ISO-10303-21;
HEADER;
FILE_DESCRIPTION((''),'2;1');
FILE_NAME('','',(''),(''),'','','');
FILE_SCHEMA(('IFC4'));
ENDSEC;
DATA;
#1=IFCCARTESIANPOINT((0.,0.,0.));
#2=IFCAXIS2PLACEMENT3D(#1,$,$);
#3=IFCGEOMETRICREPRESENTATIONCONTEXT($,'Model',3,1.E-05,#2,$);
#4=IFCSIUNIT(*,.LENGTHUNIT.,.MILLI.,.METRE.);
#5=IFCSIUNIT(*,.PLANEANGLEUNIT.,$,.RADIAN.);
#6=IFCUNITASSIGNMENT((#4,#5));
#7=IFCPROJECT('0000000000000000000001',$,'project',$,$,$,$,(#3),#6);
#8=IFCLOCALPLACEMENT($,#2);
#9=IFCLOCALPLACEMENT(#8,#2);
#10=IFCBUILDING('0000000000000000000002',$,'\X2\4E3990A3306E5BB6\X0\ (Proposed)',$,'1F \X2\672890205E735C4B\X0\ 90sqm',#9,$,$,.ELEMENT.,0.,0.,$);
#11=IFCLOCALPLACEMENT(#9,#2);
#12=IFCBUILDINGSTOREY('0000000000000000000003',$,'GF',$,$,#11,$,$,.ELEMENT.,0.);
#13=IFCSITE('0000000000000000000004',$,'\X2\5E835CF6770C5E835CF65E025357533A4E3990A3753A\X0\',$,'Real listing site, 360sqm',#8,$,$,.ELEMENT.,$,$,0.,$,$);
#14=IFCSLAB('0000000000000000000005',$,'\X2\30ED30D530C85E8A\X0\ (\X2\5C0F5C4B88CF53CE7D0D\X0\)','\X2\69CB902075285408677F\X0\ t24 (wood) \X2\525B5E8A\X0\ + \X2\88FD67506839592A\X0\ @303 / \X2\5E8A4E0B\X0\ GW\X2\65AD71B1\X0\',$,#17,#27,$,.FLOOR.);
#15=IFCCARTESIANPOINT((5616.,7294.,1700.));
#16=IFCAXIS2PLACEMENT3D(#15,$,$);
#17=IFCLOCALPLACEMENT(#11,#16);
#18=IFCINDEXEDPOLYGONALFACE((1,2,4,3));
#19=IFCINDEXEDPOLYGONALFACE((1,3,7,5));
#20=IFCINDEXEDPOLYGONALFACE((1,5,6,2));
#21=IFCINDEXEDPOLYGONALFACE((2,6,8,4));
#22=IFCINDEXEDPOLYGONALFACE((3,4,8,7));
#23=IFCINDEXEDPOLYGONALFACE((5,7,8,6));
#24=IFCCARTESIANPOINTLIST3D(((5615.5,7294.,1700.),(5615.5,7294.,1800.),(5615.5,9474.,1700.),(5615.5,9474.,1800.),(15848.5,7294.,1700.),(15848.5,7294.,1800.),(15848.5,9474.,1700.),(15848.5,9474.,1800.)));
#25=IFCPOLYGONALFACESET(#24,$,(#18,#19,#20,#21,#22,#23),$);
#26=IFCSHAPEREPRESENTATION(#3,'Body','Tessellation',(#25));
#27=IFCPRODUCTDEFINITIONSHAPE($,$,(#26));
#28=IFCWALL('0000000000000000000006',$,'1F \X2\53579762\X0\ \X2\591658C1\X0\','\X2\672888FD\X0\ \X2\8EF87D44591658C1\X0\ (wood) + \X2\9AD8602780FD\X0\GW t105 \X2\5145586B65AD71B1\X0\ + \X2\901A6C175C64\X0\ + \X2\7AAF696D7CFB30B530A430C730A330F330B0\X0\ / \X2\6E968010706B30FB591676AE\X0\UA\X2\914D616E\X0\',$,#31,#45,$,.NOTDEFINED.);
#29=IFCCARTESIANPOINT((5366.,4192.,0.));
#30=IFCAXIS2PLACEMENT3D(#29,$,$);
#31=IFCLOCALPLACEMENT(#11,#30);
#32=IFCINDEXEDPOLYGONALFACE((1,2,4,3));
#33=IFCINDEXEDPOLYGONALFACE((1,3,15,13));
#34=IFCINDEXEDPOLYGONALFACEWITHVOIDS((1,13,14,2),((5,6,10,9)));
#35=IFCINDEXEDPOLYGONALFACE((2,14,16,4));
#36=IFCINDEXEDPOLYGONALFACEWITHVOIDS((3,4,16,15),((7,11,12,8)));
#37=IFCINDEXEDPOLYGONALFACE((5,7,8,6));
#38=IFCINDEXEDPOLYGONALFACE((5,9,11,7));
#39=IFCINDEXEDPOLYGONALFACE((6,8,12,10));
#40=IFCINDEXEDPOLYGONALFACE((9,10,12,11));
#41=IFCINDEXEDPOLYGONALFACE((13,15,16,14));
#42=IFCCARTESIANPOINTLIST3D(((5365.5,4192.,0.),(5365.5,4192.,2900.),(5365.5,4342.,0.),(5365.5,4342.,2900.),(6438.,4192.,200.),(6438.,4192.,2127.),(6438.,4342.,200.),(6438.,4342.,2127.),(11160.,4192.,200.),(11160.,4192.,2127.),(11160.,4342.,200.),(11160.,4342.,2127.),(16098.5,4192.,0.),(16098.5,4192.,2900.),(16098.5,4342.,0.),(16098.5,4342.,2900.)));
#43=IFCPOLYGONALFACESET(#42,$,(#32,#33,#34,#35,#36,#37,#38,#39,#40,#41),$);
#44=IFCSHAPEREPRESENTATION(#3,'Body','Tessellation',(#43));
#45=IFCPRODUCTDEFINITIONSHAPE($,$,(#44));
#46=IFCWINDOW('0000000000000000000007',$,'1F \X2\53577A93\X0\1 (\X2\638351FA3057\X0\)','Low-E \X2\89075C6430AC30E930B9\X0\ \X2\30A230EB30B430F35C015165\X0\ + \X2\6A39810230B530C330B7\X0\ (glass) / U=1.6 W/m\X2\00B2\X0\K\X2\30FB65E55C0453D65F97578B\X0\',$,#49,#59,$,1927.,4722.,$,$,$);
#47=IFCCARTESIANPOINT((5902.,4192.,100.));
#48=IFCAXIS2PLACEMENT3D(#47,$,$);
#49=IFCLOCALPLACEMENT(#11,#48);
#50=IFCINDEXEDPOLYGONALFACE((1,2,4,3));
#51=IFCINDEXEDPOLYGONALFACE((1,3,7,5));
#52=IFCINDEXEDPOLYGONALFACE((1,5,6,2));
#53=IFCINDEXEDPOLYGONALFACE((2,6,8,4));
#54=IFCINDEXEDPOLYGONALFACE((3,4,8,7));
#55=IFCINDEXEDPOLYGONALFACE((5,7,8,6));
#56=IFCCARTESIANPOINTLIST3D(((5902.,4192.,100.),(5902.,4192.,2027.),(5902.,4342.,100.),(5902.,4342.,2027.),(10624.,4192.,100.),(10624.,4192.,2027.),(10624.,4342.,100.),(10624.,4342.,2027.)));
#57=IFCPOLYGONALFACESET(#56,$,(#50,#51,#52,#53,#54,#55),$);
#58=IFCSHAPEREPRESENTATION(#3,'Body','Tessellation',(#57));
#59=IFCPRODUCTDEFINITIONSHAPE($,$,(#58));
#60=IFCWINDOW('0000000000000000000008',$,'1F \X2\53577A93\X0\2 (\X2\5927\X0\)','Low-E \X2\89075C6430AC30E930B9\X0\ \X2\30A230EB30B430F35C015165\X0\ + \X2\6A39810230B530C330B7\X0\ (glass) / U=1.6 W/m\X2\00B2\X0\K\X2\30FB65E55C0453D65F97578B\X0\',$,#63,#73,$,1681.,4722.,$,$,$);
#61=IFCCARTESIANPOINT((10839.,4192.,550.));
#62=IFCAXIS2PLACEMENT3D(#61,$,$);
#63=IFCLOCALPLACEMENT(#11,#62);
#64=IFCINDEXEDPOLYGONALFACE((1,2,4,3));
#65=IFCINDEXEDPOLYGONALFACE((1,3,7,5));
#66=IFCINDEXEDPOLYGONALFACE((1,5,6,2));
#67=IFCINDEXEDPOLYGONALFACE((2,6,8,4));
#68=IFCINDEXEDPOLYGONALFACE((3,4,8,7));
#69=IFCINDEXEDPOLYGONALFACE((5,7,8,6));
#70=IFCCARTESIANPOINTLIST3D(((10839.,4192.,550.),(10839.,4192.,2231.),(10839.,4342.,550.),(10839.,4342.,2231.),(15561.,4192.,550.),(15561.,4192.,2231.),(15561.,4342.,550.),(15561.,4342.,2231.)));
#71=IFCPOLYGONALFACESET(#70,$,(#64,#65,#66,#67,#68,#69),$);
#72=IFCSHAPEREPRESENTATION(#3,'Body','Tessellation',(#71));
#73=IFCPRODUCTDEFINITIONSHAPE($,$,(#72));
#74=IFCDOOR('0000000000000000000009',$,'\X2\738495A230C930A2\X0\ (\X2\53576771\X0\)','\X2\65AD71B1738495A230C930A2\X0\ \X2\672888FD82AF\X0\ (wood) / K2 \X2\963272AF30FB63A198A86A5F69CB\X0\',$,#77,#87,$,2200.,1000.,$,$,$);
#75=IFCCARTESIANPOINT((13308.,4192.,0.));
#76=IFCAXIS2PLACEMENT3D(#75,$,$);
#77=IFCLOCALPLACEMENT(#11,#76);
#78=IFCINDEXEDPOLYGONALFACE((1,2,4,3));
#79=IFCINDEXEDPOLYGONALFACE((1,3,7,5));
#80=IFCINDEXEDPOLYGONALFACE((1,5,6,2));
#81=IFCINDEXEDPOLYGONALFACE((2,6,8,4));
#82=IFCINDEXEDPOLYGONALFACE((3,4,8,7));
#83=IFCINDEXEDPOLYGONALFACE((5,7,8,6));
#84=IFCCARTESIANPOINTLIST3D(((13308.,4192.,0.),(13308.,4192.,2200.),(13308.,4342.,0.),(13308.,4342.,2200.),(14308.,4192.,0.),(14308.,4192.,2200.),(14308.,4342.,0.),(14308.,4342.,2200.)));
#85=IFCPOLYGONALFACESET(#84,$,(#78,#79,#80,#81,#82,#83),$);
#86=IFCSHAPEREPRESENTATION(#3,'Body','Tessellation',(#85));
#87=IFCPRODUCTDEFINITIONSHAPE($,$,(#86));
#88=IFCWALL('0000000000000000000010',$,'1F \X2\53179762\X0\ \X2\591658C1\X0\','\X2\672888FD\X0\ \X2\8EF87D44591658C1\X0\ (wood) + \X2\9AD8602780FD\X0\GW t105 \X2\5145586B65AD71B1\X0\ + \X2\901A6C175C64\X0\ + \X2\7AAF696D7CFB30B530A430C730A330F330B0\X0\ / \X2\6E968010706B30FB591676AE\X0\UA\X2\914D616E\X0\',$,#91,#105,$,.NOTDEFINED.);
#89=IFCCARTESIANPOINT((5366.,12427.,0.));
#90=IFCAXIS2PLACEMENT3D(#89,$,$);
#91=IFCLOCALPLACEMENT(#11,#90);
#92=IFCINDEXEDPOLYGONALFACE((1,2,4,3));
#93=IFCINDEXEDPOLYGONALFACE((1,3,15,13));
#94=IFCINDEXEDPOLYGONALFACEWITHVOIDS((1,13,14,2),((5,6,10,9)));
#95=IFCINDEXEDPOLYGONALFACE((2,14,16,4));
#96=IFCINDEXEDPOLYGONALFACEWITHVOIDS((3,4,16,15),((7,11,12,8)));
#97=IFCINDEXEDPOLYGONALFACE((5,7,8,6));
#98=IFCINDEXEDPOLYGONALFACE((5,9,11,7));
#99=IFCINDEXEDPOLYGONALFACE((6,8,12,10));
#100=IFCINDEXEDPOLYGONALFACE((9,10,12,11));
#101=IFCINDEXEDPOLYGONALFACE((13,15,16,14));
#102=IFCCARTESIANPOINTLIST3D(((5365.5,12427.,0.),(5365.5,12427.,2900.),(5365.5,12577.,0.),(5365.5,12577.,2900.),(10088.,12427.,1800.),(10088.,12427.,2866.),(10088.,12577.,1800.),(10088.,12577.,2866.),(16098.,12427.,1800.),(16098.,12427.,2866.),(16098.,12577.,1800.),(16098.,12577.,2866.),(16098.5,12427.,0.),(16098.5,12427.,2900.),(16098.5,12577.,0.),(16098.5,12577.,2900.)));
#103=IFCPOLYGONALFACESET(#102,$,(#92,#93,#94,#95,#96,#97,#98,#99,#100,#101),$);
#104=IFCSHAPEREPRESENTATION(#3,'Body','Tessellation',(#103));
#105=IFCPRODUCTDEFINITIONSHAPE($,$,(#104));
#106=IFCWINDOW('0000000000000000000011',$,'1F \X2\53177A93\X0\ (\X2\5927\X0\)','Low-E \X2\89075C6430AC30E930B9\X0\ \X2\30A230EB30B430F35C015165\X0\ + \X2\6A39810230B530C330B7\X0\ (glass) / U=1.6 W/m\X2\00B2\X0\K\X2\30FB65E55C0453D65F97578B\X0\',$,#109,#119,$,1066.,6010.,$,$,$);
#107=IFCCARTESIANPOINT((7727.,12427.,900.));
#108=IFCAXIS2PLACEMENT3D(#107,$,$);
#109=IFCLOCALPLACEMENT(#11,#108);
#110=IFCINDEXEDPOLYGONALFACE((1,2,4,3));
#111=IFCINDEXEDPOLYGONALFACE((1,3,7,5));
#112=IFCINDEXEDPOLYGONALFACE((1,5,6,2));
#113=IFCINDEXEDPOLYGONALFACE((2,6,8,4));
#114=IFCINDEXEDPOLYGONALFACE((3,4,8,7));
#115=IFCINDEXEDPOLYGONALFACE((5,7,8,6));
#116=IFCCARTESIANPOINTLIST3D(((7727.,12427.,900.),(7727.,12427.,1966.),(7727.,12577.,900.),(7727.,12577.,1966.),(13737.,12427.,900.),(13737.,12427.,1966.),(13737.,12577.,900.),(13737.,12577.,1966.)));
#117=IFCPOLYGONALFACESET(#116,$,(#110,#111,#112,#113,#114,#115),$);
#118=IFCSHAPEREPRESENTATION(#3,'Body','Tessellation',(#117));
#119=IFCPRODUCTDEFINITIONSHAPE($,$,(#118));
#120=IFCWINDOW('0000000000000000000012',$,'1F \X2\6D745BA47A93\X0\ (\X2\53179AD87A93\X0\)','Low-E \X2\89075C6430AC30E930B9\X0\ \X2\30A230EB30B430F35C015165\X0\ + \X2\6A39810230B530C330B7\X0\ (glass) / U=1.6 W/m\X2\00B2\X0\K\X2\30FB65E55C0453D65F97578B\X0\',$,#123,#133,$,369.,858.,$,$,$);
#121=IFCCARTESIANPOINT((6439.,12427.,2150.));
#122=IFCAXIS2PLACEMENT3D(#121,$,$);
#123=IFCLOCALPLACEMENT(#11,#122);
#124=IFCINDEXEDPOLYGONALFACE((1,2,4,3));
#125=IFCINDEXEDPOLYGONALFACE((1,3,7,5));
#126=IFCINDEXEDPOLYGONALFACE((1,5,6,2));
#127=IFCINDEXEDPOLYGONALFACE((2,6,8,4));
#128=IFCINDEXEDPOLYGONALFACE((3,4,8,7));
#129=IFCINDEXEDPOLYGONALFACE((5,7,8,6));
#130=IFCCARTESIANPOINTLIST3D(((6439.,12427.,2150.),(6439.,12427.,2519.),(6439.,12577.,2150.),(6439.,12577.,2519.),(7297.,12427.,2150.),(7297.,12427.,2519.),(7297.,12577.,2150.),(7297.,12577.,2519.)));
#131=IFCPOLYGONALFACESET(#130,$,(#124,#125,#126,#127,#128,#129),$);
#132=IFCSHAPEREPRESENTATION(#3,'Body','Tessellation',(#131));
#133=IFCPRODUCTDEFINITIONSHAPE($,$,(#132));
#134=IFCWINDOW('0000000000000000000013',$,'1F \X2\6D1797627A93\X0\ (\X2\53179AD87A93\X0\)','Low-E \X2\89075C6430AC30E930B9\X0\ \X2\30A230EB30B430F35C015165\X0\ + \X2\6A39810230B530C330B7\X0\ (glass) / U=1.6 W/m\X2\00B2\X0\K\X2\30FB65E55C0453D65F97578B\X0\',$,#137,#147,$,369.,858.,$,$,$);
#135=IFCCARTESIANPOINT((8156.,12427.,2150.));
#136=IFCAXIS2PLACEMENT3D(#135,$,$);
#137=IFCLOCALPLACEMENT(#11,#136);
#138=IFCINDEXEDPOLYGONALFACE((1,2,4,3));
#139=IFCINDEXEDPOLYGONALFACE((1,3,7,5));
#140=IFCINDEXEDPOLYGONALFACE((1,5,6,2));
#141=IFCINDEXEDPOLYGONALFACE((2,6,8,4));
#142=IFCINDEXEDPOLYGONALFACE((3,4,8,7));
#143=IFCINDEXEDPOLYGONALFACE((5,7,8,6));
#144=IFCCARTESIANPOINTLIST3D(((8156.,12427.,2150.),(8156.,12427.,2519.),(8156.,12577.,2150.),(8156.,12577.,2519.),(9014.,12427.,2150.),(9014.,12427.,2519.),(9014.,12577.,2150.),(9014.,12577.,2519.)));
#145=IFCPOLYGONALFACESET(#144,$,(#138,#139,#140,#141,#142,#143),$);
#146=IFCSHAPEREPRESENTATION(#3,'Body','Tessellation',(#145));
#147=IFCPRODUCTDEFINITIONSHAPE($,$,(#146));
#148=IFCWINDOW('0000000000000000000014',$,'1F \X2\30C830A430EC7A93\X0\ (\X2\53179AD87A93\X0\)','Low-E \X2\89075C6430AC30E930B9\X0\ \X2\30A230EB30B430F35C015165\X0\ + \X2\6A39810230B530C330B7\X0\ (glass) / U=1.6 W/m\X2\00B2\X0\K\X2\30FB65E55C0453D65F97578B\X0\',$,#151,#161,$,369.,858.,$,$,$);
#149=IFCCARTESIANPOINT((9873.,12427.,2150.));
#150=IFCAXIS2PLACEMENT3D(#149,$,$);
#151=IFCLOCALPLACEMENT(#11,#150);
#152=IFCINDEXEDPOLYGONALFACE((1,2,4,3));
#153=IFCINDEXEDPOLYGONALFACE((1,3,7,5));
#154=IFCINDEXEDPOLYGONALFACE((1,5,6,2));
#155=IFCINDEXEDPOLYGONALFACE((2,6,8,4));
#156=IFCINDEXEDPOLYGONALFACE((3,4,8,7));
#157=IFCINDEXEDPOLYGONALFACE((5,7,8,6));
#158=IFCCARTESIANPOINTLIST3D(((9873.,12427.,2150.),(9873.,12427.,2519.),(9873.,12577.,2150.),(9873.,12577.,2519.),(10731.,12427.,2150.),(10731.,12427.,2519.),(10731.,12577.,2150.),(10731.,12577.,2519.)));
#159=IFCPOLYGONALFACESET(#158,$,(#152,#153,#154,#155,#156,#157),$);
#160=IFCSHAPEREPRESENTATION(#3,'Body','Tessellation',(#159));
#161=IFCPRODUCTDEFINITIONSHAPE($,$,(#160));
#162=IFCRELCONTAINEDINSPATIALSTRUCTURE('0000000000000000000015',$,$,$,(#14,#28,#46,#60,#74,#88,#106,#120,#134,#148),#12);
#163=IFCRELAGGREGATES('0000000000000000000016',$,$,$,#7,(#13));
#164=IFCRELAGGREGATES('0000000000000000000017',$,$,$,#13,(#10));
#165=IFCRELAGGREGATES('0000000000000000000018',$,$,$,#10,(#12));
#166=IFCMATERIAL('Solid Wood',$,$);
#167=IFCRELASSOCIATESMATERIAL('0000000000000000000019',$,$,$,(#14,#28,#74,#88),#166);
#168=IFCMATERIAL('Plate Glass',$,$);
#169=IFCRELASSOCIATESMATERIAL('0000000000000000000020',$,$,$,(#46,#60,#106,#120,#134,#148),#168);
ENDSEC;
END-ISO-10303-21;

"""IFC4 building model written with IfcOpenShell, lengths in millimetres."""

from ifc_helpers import new_model, si_unit, frame, frame_2d, origin, place, context, project, spatial, rectangle, extrude, material, element, fill, save


model = new_model("IFC4")

# Units and contexts
model_context = context("Model", 3, precision=1e-05, world=origin())
ifc_project = project(units=[si_unit("LENGTHUNIT", "METRE", prefix="MILLI"), si_unit("PLANEANGLEUNIT", "RADIAN")], contexts=[model_context])

# Site, building, storey
site_placement = place(None, origin())
site = spatial("IfcSite", under=ifc_project, at=site_placement, Name="広島県広島市南区丹那町", ObjectType="Real listing site, 360sqm", CompositionType="ELEMENT", RefElevation=0.0)
building_placement = place(site_placement, origin())
building = spatial("IfcBuilding", under=site, at=building_placement, Name="丹那の家 (Proposed)", ObjectType="1F 木造平屋 90sqm", CompositionType="ELEMENT", ElevationOfRefHeight=0.0, ElevationOfTerrain=0.0)
storey_placement = place(building_placement, origin())
storey = spatial("IfcBuildingStorey", under=building, at=storey_placement, Name="GF", CompositionType="ELEMENT", Elevation=0.0)

# Slab
ifc_material_1 = material(Name="Solid Wood")
slab_1_placement = place(storey_placement, frame((5616.0, 7294.0, 1700.0)))
element("IfcSlab", 1, at=slab_1_placement, inside=storey, material=ifc_material_1, Name="ロフト床 (小屋裏収納)", Description="構造用合板 t24 (wood) 剛床 + 製材根太 @303 / 床下 GW断熱", PredefinedType="FLOOR", context=model_context, shape_type="SweptSolid", body=[
    extrude(rectangle(XDim=10233.0, YDim=2180.0, at=frame_2d((5116.0, 1090.0))), frame((5616.0, 7294.0, 1700.0)), (0.0, 0.0, 1.0), 100.0),
])

# Wall, openings, windows, door
wall_1_placement = place(storey_placement, frame((5366.0, 4192.0, 0.0)))
wall_1 = element("IfcWall", 2, at=wall_1_placement, inside=storey, material=ifc_material_1, Name="1F 南面 外壁", Description="木製 軸組外壁 (wood) + 高性能GW t105 充填断熱 + 通気層 + 窯業系サイディング / 準耐火・外皮UA配慮", PredefinedType="NOTDEFINED", context=model_context, shape_type="SweptSolid", body=[
    extrude(rectangle(XDim=10733.0, YDim=150.0, at=frame_2d((5366.0, 75.0))), frame((5366.0, 4192.0, 0.0)), (0.0, 0.0, 1.0), 2900.0),
])
opening_1_placement = place(storey_placement, frame((5902.0, 4192.0, 100.0)))
opening_1 = element("IfcOpeningElement", 3, at=opening_1_placement, cuts=wall_1, PredefinedType="NOTDEFINED", context=model_context, shape_type="SweptSolid", body=[
    extrude(rectangle(XDim=4722.0, YDim=150.0, at=frame_2d((2361.0, 75.0))), frame((5902.0, 4192.0, 100.0)), (0.0, 0.0, 1.0), 1927.0),
])
opening_2_placement = place(storey_placement, frame((10839.0, 4192.0, 550.0)))
opening_2 = element("IfcOpeningElement", 4, at=opening_2_placement, cuts=wall_1, PredefinedType="NOTDEFINED", context=model_context, shape_type="SweptSolid", body=[
    extrude(rectangle(XDim=4722.0, YDim=150.0, at=frame_2d((2361.0, 75.0))), frame((10839.0, 4192.0, 550.0)), (0.0, 0.0, 1.0), 1681.0),
])
opening_3_placement = place(storey_placement, frame((13308.0, 4192.0, 0.0)))
opening_3 = element("IfcOpeningElement", 5, at=opening_3_placement, cuts=wall_1, PredefinedType="NOTDEFINED", context=model_context, shape_type="SweptSolid", body=[
    extrude(rectangle(XDim=1000.0, YDim=150.0, at=frame_2d((500.0, 75.0))), frame((13308.0, 4192.0, 0.0)), (0.0, 0.0, 1.0), 2200.0),
])
ifc_material_2 = material(Name="Plate Glass")
window_1_placement = place(storey_placement, frame((5902.0, 4192.0, 100.0)))
window_1 = element("IfcWindow", 6, at=window_1_placement, inside=storey, material=ifc_material_2, Name="1F 南窓1 (掃出し)", Description="Low-E 複層ガラス アルゴン封入 + 樹脂サッシ (glass) / U=1.6 W/m²K・日射取得型", OverallHeight=1927.0, OverallWidth=4722.0, context=model_context, shape_type="SweptSolid", body=[
    extrude(rectangle(XDim=4722.0, YDim=150.0, at=frame_2d((2361.0, 75.0))), frame((5902.0, 4192.0, 100.0)), (0.0, 0.0, 1.0), 1927.0),
])
fill(opening_1, window_1)
window_2_placement = place(storey_placement, frame((10839.0, 4192.0, 550.0)))
window_2 = element("IfcWindow", 7, at=window_2_placement, inside=storey, material=ifc_material_2, Name="1F 南窓2 (大)", Description="Low-E 複層ガラス アルゴン封入 + 樹脂サッシ (glass) / U=1.6 W/m²K・日射取得型", OverallHeight=1681.0, OverallWidth=4722.0, context=model_context, shape_type="SweptSolid", body=[
    extrude(rectangle(XDim=4722.0, YDim=150.0, at=frame_2d((2361.0, 75.0))), frame((10839.0, 4192.0, 550.0)), (0.0, 0.0, 1.0), 1681.0),
])
fill(opening_2, window_2)
door_1_placement = place(storey_placement, frame((13308.0, 4192.0, 0.0)))
door_1 = element("IfcDoor", 8, at=door_1_placement, inside=storey, material=ifc_material_1, Name="玄関ドア (南東)", Description="断熱玄関ドア 木製芯 (wood) / K2 防犯・採風機構", OverallHeight=2200.0, OverallWidth=1000.0, context=model_context, shape_type="SweptSolid", body=[
    extrude(rectangle(XDim=1000.0, YDim=150.0, at=frame_2d((500.0, 75.0))), frame((13308.0, 4192.0, 0.0)), (0.0, 0.0, 1.0), 2200.0),
])
fill(opening_3, door_1)

# Wall, openings, windows
wall_2_placement = place(storey_placement, frame((5366.0, 12427.0, 0.0)))
wall_2 = element("IfcWall", 9, at=wall_2_placement, inside=storey, material=ifc_material_1, Name="1F 北面 外壁", Description="木製 軸組外壁 (wood) + 高性能GW t105 充填断熱 + 通気層 + 窯業系サイディング / 準耐火・外皮UA配慮", PredefinedType="NOTDEFINED", context=model_context, shape_type="SweptSolid", body=[
    extrude(rectangle(XDim=10733.0, YDim=150.0, at=frame_2d((5366.0, 75.0))), frame((5366.0, 12427.0, 0.0)), (0.0, 0.0, 1.0), 2900.0),
])
opening_4_placement = place(storey_placement, frame((7727.0, 12427.0, 900.0)))
opening_4 = element("IfcOpeningElement", 10, at=opening_4_placement, cuts=wall_2, PredefinedType="NOTDEFINED", context=model_context, shape_type="SweptSolid", body=[
    extrude(rectangle(XDim=6010.0, YDim=150.0, at=frame_2d((3005.0, 75.0))), frame((7727.0, 12427.0, 900.0)), (0.0, 0.0, 1.0), 1066.0),
])
opening_5_placement = place(storey_placement, frame((6439.0, 12427.0, 2150.0)))
opening_5 = element("IfcOpeningElement", 11, at=opening_5_placement, cuts=wall_2, PredefinedType="NOTDEFINED", context=model_context, shape_type="SweptSolid", body=[
    extrude(rectangle(XDim=858.0, YDim=150.0, at=frame_2d((429.0, 75.0))), frame((6439.0, 12427.0, 2150.0)), (0.0, 0.0, 1.0), 369.0),
])
opening_6_placement = place(storey_placement, frame((8156.0, 12427.0, 2150.0)))
opening_6 = element("IfcOpeningElement", 12, at=opening_6_placement, cuts=wall_2, PredefinedType="NOTDEFINED", context=model_context, shape_type="SweptSolid", body=[
    extrude(rectangle(XDim=858.0, YDim=150.0, at=frame_2d((429.0, 75.0))), frame((8156.0, 12427.0, 2150.0)), (0.0, 0.0, 1.0), 369.0),
])
opening_7_placement = place(storey_placement, frame((9873.0, 12427.0, 2150.0)))
opening_7 = element("IfcOpeningElement", 13, at=opening_7_placement, cuts=wall_2, PredefinedType="NOTDEFINED", context=model_context, shape_type="SweptSolid", body=[
    extrude(rectangle(XDim=858.0, YDim=150.0, at=frame_2d((429.0, 75.0))), frame((9873.0, 12427.0, 2150.0)), (0.0, 0.0, 1.0), 369.0),
])
window_3_placement = place(storey_placement, frame((7727.0, 12427.0, 900.0)))
window_3 = element("IfcWindow", 14, at=window_3_placement, inside=storey, material=ifc_material_2, Name="1F 北窓 (大)", Description="Low-E 複層ガラス アルゴン封入 + 樹脂サッシ (glass) / U=1.6 W/m²K・日射取得型", OverallHeight=1066.0, OverallWidth=6010.0, context=model_context, shape_type="SweptSolid", body=[
    extrude(rectangle(XDim=6010.0, YDim=150.0, at=frame_2d((3005.0, 75.0))), frame((7727.0, 12427.0, 900.0)), (0.0, 0.0, 1.0), 1066.0),
])
fill(opening_4, window_3)
window_4_placement = place(storey_placement, frame((6439.0, 12427.0, 2150.0)))
window_4 = element("IfcWindow", 15, at=window_4_placement, inside=storey, material=ifc_material_2, Name="1F 浴室窓 (北高窓)", Description="Low-E 複層ガラス アルゴン封入 + 樹脂サッシ (glass) / U=1.6 W/m²K・日射取得型", OverallHeight=369.0, OverallWidth=858.0, context=model_context, shape_type="SweptSolid", body=[
    extrude(rectangle(XDim=858.0, YDim=150.0, at=frame_2d((429.0, 75.0))), frame((6439.0, 12427.0, 2150.0)), (0.0, 0.0, 1.0), 369.0),
])
fill(opening_5, window_4)
window_5_placement = place(storey_placement, frame((8156.0, 12427.0, 2150.0)))
window_5 = element("IfcWindow", 16, at=window_5_placement, inside=storey, material=ifc_material_2, Name="1F 洗面窓 (北高窓)", Description="Low-E 複層ガラス アルゴン封入 + 樹脂サッシ (glass) / U=1.6 W/m²K・日射取得型", OverallHeight=369.0, OverallWidth=858.0, context=model_context, shape_type="SweptSolid", body=[
    extrude(rectangle(XDim=858.0, YDim=150.0, at=frame_2d((429.0, 75.0))), frame((8156.0, 12427.0, 2150.0)), (0.0, 0.0, 1.0), 369.0),
])
fill(opening_6, window_5)
window_6_placement = place(storey_placement, frame((9873.0, 12427.0, 2150.0)))
window_6 = element("IfcWindow", 17, at=window_6_placement, inside=storey, material=ifc_material_2, Name="1F トイレ窓 (北高窓)", Description="Low-E 複層ガラス アルゴン封入 + 樹脂サッシ (glass) / U=1.6 W/m²K・日射取得型", OverallHeight=369.0, OverallWidth=858.0, context=model_context, shape_type="SweptSolid", body=[
    extrude(rectangle(XDim=858.0, YDim=150.0, at=frame_2d((429.0, 75.0))), frame((9873.0, 12427.0, 2150.0)), (0.0, 0.0, 1.0), 369.0),
])
fill(opening_7, window_6)

save(model, "model.ifc")
